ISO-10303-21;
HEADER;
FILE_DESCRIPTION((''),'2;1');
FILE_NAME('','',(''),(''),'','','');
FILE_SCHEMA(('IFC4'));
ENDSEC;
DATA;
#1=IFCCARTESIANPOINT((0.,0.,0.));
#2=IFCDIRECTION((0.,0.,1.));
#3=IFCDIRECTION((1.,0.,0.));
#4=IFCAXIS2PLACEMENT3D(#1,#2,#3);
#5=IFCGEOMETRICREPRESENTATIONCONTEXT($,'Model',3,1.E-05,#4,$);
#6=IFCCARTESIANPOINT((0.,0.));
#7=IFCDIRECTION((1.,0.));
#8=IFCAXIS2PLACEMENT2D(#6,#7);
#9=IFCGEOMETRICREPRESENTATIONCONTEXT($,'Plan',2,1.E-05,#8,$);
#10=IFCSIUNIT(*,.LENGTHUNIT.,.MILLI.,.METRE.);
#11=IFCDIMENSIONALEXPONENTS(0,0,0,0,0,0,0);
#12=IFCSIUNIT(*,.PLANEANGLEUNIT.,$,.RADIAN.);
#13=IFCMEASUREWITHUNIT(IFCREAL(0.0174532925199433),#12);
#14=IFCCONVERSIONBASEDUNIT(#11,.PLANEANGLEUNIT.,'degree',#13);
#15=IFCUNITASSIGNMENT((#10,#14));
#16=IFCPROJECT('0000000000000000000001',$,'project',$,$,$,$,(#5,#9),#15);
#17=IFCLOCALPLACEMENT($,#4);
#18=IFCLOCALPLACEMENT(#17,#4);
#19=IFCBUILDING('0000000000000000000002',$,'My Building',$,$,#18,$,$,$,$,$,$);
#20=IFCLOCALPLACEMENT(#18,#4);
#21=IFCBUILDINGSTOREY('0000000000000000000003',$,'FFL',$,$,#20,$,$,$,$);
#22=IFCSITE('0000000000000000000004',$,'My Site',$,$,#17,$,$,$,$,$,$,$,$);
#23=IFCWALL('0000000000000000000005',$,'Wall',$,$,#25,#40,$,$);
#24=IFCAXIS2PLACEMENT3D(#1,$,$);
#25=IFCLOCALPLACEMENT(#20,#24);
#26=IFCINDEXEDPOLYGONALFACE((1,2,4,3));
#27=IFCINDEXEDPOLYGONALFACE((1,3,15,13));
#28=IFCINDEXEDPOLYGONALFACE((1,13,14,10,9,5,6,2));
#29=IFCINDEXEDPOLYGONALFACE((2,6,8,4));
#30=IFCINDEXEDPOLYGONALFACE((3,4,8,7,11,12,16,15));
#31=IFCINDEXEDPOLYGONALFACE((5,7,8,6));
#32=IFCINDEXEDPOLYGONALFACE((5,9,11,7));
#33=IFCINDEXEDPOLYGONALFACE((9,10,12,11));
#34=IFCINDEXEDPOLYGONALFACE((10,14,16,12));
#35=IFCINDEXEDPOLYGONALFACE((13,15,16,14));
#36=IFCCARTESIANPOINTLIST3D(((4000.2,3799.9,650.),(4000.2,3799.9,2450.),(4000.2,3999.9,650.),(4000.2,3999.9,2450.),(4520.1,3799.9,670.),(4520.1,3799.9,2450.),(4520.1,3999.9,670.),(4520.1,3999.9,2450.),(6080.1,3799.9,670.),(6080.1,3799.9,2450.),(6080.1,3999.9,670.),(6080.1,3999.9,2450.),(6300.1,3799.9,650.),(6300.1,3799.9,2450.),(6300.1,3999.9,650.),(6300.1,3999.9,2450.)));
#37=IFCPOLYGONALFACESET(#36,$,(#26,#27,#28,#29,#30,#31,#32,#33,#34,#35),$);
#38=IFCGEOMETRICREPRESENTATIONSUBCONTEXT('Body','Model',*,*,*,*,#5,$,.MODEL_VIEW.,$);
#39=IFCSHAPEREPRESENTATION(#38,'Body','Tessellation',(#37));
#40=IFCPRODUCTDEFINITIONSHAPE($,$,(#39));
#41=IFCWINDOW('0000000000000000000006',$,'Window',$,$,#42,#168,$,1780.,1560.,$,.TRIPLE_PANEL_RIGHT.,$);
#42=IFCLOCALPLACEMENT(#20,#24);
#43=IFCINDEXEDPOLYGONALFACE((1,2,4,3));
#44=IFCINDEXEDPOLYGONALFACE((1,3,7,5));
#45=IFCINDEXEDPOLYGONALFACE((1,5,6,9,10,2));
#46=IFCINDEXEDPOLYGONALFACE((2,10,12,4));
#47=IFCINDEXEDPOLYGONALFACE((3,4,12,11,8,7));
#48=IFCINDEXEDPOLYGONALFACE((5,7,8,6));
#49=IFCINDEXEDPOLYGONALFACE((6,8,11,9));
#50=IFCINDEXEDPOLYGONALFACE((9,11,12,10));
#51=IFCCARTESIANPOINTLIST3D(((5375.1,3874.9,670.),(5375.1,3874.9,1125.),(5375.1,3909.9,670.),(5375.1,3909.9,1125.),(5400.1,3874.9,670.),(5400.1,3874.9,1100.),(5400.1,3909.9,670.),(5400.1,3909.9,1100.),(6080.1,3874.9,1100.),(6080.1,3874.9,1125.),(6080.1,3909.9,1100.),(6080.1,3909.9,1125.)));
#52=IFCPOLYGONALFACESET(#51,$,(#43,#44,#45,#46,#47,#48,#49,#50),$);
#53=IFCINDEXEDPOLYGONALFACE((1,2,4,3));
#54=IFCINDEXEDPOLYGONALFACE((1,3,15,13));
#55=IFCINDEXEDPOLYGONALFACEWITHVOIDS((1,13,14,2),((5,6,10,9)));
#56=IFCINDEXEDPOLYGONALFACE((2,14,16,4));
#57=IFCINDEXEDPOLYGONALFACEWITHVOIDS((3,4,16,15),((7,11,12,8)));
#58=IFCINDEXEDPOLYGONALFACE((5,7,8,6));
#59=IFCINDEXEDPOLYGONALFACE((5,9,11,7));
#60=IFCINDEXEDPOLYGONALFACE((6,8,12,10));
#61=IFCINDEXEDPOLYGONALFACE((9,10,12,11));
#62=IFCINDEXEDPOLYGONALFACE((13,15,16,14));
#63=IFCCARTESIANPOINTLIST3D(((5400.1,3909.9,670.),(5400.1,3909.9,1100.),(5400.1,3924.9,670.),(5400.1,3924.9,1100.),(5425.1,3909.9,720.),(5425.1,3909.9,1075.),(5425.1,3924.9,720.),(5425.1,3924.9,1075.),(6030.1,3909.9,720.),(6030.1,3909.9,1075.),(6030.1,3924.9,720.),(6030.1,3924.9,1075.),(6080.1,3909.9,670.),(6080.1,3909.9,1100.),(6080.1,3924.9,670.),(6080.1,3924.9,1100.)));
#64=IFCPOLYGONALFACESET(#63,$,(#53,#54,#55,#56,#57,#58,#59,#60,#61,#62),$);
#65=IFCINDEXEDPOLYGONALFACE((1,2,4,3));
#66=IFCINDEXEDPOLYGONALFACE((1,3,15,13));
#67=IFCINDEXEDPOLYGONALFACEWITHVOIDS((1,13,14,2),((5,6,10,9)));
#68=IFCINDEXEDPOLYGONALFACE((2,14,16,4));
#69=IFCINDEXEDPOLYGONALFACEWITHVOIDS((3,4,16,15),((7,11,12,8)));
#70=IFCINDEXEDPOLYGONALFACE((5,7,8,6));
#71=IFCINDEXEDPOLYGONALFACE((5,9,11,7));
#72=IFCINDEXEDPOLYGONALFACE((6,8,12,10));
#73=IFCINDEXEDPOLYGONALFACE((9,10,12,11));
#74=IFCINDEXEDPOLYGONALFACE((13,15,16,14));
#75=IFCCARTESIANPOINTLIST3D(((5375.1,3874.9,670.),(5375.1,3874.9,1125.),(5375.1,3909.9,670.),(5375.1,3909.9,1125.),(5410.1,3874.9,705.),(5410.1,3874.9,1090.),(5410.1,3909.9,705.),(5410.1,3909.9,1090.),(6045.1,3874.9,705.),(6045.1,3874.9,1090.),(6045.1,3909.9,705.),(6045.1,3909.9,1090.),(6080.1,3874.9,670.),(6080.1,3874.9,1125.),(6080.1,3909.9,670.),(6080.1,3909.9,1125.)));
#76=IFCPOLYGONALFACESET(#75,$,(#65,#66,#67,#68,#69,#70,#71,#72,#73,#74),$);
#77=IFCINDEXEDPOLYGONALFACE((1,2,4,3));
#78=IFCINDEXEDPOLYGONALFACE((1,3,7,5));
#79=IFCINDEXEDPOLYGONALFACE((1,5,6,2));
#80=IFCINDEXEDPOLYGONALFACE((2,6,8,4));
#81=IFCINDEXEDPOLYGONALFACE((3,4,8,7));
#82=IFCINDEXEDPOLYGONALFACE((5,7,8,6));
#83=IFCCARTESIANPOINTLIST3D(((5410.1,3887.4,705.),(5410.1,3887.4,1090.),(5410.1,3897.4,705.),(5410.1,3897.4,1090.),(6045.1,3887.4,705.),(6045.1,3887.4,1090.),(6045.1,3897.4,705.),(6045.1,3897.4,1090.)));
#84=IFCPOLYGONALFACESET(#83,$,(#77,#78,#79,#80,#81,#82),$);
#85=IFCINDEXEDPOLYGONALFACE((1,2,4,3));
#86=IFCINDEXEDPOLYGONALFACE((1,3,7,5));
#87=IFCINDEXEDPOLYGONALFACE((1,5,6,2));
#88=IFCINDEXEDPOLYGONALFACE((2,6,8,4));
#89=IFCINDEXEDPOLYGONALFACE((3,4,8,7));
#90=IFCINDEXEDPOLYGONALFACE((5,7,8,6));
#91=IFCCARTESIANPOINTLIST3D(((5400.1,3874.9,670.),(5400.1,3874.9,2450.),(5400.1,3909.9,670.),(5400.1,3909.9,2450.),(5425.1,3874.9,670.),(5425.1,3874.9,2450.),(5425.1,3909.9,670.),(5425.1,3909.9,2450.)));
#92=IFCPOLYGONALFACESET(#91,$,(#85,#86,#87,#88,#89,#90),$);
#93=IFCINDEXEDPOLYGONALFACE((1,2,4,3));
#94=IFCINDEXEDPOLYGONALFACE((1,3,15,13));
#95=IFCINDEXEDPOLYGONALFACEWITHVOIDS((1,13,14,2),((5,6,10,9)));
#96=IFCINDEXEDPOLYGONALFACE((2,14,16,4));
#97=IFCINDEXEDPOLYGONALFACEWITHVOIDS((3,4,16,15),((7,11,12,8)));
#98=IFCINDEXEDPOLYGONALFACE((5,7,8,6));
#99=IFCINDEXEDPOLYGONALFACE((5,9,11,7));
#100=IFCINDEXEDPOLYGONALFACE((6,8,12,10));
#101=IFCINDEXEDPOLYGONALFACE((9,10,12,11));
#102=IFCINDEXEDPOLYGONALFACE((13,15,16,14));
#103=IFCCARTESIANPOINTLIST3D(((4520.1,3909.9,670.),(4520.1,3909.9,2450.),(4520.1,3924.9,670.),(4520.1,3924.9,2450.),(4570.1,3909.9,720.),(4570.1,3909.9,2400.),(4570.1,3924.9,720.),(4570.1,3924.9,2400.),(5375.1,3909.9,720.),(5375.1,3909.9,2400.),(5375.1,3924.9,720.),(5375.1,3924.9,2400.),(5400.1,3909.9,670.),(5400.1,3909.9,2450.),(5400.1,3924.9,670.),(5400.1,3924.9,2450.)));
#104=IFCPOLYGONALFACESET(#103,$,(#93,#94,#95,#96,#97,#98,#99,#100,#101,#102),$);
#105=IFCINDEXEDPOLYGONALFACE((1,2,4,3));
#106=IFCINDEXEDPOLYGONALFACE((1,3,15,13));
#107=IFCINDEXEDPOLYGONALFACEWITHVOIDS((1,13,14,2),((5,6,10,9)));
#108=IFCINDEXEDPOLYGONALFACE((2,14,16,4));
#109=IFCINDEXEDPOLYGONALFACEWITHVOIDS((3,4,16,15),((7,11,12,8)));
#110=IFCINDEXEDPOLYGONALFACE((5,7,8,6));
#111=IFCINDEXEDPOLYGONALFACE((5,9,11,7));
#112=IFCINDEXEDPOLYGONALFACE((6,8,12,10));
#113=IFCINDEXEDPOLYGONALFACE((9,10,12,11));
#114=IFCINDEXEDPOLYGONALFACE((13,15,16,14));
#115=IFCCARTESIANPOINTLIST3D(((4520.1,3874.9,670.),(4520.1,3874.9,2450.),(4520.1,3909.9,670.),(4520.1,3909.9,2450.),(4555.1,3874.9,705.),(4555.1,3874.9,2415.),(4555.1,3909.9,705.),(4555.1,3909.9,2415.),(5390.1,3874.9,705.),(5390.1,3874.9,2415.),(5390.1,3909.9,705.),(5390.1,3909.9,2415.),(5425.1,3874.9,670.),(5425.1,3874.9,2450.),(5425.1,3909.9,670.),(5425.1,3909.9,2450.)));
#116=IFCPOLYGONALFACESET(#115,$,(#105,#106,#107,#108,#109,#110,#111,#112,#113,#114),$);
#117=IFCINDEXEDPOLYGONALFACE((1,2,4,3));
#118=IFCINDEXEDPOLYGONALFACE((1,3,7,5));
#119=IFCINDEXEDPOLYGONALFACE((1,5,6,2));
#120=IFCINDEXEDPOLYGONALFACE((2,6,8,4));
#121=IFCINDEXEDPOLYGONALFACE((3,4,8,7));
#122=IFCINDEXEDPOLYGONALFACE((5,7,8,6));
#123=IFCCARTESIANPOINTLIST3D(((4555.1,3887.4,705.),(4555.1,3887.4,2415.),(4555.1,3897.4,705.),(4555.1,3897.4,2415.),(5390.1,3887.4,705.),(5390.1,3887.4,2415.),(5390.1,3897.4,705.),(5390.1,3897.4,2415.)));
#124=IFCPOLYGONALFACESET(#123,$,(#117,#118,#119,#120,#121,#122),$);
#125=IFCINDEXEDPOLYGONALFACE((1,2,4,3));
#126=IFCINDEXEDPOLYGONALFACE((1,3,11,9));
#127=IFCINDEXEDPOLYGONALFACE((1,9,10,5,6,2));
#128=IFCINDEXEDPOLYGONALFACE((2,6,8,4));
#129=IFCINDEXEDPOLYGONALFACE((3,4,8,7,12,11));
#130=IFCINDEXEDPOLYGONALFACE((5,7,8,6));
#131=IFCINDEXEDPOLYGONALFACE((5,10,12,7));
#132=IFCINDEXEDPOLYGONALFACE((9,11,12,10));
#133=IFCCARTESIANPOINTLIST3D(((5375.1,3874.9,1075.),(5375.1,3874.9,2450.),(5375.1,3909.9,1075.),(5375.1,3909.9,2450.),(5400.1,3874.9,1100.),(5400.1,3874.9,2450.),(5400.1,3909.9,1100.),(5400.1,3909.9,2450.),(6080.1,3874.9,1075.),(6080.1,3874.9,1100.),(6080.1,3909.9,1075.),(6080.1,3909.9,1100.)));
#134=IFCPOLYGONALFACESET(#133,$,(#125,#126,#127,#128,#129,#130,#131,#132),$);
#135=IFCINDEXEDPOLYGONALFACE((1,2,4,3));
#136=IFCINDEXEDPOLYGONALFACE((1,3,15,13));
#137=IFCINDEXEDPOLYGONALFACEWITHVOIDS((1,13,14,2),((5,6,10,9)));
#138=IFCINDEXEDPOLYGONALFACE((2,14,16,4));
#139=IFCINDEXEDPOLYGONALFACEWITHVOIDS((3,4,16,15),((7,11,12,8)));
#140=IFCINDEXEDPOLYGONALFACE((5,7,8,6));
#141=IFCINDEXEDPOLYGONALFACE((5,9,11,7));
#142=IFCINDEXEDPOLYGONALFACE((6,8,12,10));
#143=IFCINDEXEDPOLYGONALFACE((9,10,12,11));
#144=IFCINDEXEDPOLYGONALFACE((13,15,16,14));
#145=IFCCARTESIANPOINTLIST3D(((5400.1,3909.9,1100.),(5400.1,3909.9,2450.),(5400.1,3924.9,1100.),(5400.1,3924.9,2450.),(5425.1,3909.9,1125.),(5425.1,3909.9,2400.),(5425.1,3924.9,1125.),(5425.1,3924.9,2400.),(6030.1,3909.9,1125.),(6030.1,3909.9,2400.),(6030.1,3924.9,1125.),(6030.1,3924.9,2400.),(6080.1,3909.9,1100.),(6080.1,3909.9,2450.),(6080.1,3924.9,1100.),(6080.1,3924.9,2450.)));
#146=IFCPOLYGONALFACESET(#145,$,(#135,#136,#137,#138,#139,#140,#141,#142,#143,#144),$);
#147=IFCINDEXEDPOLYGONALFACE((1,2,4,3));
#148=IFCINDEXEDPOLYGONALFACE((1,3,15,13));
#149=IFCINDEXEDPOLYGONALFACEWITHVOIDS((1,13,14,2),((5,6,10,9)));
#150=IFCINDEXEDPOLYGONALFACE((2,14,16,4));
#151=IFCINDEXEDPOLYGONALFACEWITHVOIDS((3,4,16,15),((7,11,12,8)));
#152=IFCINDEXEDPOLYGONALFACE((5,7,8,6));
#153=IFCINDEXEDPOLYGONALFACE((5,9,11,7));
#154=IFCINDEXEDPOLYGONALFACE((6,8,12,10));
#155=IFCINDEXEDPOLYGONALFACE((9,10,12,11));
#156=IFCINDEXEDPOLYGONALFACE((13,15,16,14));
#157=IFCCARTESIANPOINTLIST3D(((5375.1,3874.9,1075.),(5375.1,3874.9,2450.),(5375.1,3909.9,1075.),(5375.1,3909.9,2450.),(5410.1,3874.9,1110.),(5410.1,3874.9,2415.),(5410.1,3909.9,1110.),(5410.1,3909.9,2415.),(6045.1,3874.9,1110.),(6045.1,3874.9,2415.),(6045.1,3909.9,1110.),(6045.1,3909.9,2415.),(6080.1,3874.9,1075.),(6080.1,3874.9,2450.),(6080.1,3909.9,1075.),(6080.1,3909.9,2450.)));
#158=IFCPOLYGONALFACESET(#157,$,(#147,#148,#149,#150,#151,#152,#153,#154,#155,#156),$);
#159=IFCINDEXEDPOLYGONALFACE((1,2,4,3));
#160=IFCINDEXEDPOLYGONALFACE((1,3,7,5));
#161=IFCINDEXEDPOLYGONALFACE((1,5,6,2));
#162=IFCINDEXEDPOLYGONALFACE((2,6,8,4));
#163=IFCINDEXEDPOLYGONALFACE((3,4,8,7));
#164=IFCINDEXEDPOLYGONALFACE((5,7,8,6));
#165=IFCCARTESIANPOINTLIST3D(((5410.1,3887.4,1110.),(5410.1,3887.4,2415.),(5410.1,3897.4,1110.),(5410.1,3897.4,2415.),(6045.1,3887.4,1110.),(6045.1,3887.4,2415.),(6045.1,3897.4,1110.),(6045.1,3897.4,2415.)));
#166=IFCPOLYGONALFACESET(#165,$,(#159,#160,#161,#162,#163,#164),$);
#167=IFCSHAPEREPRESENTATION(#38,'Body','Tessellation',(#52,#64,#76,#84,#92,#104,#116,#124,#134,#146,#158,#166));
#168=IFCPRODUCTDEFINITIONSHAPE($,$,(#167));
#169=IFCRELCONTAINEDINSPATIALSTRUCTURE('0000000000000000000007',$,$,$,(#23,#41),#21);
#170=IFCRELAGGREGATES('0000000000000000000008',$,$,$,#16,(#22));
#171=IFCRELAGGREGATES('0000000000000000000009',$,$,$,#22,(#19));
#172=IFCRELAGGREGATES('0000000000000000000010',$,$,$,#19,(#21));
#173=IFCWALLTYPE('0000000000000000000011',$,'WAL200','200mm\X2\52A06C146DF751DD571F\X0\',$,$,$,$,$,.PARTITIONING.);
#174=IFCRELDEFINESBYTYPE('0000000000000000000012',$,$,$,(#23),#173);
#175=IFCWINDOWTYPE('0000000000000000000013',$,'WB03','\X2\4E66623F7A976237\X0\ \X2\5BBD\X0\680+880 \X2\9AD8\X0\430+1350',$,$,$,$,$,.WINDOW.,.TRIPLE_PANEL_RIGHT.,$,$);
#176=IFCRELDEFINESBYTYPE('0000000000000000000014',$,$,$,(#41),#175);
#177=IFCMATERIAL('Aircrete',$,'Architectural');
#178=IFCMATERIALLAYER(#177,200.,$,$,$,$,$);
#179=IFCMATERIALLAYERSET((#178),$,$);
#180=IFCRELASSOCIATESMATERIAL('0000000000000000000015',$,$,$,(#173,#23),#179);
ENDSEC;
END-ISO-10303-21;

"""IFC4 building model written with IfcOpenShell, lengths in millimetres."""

from ifc_helpers import new_model, entity, si_unit, converted_unit, frame, origin_with_axes, origin_2d_with_axis, place, context, subcontext, project, spatial, line, indexed_curve, outline, extrude, shape, source, transform, mapped, material, layer, layer_set, layer_usage, type_object, type_shapes, element, fill, save


model = new_model("IFC4")

# Units and contexts
model_context = context("Model", 3, precision=1e-05, world=origin_with_axes())
plan_context = context("Plan", 2, precision=1e-05, world=origin_2d_with_axis())
body_context_1 = subcontext(model_context, "Body", "Model", "MODEL_VIEW")
body_context_2 = subcontext(plan_context, "Body", "Plan", "PLAN_VIEW")
ifc_project = project(units=[si_unit("LENGTHUNIT", "METRE", prefix="MILLI"), converted_unit("PLANEANGLEUNIT", "degree", entity("IfcReal", 0.0174532925199433), si_unit("PLANEANGLEUNIT", "RADIAN"), dimensions=[0, 0, 0, 0, 0, 0, 0])], contexts=[model_context, plan_context])

# Site, building, storey
site_placement = place(None, origin_with_axes())
site = spatial("IfcSite", under=ifc_project, at=site_placement, Name="My Site")
building_placement = place(site_placement, origin_with_axes())
building = spatial("IfcBuilding", under=site, at=building_placement, Name="My Building")
storey_placement = place(building_placement, origin_with_axes())
storey = spatial("IfcBuildingStorey", under=building, at=storey_placement, Name="FFL")

# Shared definitions
ifc_material_1 = material(Name="Aircrete", Category="Architectural")

# Shared definitions
ifc_layer_1 = layer(ifc_material_1, 200.0)
ifc_layer_set_1 = layer_set([ifc_layer_1])
wall_type_1 = type_object("IfcWallType", Name="WAL200", Description="200mm加气混凝土", PredefinedType="PARTITIONING", material=ifc_layer_set_1)

# Wall, opening, window
ifc_layer_usage_1 = layer_usage(ifc_layer_set_1, "AXIS2", "NEGATIVE", 0.0)
wall_1_placement = place(storey_placement, frame((6300.1, 3799.9, 650.0), z_axis=(0.0, 0.0, 1.0), x_axis=(-1.0, 0.0, 0.0)))
wall_1 = element("IfcWall", 1, at=wall_1_placement, inside=storey, type_object=wall_type_1, material=ifc_layer_usage_1, Name="Wall", context=body_context_1, shape_type="SweptSolid", body=[
    extrude(outline(indexed_curve([(0.0, -200.0), (0.0, 0.0), (2299.9, 0.0), (2299.9, -200.0)], segments=[line(1, 2, 3, 4, 1)])), origin_with_axes(), (0.0, 0.0, 1.0), 1800.0),
])
shared_shape_1 = source(origin_with_axes(), body_context_1, "Body", "SweptSolid", [
    extrude(outline(indexed_curve([(0.0, 0.0), (1560.0, 0.0), (1560.0, 1780.0), (0.0, 1780.0)], segments=[line(1, 2, 3, 4, 1)])), frame((0.0, -600.0, 0.0), z_axis=(0.0, -1.0, 0.0), x_axis=(1.0, 0.0, 0.0)), (0.0, 0.0, -1.0), 1200.0),
])
opening_1_placement = place(wall_1_placement, frame((220.0, -175.0, 20.0), z_axis=(0.0, 0.0, 1.0), x_axis=(1.0, 0.0, 0.0)))
opening_1 = element("IfcOpeningElement", 2, at=opening_1_placement, cuts=wall_1, PredefinedType="OPENING", context=body_context_1, shape_type="MappedRepresentation", body=[
    mapped(shared_shape_1, transform((0.0, 0.0, 0.0), x_axis=(1.0, 0.0, 0.0), y_axis=(0.0, 1.0, 0.0), z_axis=(0.0, 0.0, 1.0), scale=1.0)),
])
window_type_1 = type_object("IfcWindowType", Name="WB03", Description="书房窗户 宽680+880 高430+1350", PartitioningType="TRIPLE_PANEL_RIGHT", PredefinedType="WINDOW")
shared_shape_2 = source(origin_with_axes(), body_context_1, "Body", "SweptSolid", [
    extrude(outline(indexed_curve([(0.0, 430.0), (680.0, 430.0), (680.0, 0.0), (705.0, 0.0), (705.0, 455.0), (0.0, 455.0)], segments=[line(1, 2, 3, 4, 5, 6, 1)])), frame((0.0, 65.0, 0.0), z_axis=(0.0, -1.0, 0.0), x_axis=(1.0, 0.0, 0.0)), (0.0, 0.0, -1.0), 35.0),
    extrude(outline(indexed_curve([(0.0, 0.0), (680.0, 0.0), (680.0, 430.0), (0.0, 430.0)], segments=[line(1, 2, 3, 4, 1)]), holes=[indexed_curve([(50.0, 50.0), (655.0, 50.0), (655.0, 405.0), (50.0, 405.0)], segments=[line(1, 2, 3, 4, 1)])]), frame((0.0, 50.0, 0.0), z_axis=(0.0, -1.0, 0.0), x_axis=(1.0, 0.0, 0.0)), (0.0, 0.0, -1.0), 15.0),
    extrude(outline(indexed_curve([(0.0, 0.0), (705.0, 0.0), (705.0, 455.0), (0.0, 455.0), (0.0, 0.0)]), holes=[indexed_curve([(35.0, 35.0), (670.0, 35.0), (670.0, 420.0), (35.0, 420.0), (35.0, 35.0)])]), frame((0.0, 65.0, 0.0), z_axis=(0.0, -1.0, 0.0), x_axis=(1.0, 0.0, 0.0)), (0.0, 0.0, -1.0), 35.0),
    extrude(outline(indexed_curve([(35.0, 35.0), (670.0, 35.0), (670.0, 420.0), (35.0, 420.0)], segments=[line(1, 2, 3, 4, 1)])), frame((0.0, 77.5, 0.0), z_axis=(0.0, -1.0, 0.0), x_axis=(1.0, 0.0, 0.0)), (0.0, 0.0, -1.0), 10.0),
    extrude(outline(indexed_curve([(0.0, 0.0), (0.0, 1780.0), (-25.0, 1780.0), (-25.0, 0.0)], segments=[line(1, 2, 3, 4, 1)])), frame((680.0, 65.0, 0.0), z_axis=(0.0, -1.0, 0.0), x_axis=(1.0, 0.0, 0.0)), (0.0, 0.0, -1.0), 35.0),
    extrude(outline(indexed_curve([(0.0, 0.0), (880.0, 0.0), (880.0, 1780.0), (0.0, 1780.0)], segments=[line(1, 2, 3, 4, 1)]), holes=[indexed_curve([(25.0, 50.0), (830.0, 50.0), (830.0, 1730.0), (25.0, 1730.0)], segments=[line(1, 2, 3, 4, 1)])]), frame((680.0, 50.0, 0.0), z_axis=(0.0, -1.0, 0.0), x_axis=(1.0, 0.0, 0.0)), (0.0, 0.0, -1.0), 15.0),
    extrude(outline(indexed_curve([(0.0, 0.0), (905.0, 0.0), (905.0, 1780.0), (0.0, 1780.0)], segments=[line(1, 2, 3, 4, 1)]), holes=[indexed_curve([(35.0, 35.0), (870.0, 35.0), (870.0, 1745.0), (35.0, 1745.0)], segments=[line(1, 2, 3, 4, 1)])]), frame((655.0, 65.0, 0.0), z_axis=(0.0, -1.0, 0.0), x_axis=(1.0, 0.0, 0.0)), (0.0, 0.0, -1.0), 35.0),
    extrude(outline(indexed_curve([(35.0, 35.0), (870.0, 35.0), (870.0, 1745.0), (35.0, 1745.0)], segments=[line(1, 2, 3, 4, 1)])), frame((655.0, 77.5, 0.0), z_axis=(0.0, -1.0, 0.0), x_axis=(1.0, 0.0, 0.0)), (0.0, 0.0, -1.0), 10.0),
    extrude(outline(indexed_curve([(680.0, 1350.0), (680.0, 0.0), (0.0, 0.0), (0.0, -25.0), (705.0, -25.0), (705.0, 1350.0)], segments=[line(1, 2, 3, 4, 5, 6, 1)])), frame((0.0, 65.0, 430.0), z_axis=(0.0, -1.0, 0.0), x_axis=(1.0, 0.0, 0.0)), (0.0, 0.0, -1.0), 35.0),
    extrude(outline(indexed_curve([(0.0, 0.0), (680.0, 0.0), (680.0, 1350.0), (0.0, 1350.0)], segments=[line(1, 2, 3, 4, 1)]), holes=[indexed_curve([(50.0, 25.0), (655.0, 25.0), (655.0, 1300.0), (50.0, 1300.0)], segments=[line(1, 2, 3, 4, 1)])]), frame((0.0, 50.0, 430.0), z_axis=(0.0, -1.0, 0.0), x_axis=(1.0, 0.0, 0.0)), (0.0, 0.0, -1.0), 15.0),
    extrude(outline(indexed_curve([(0.0, 0.0), (705.0, 0.0), (705.0, 1375.0), (0.0, 1375.0)], segments=[line(1, 2, 3, 4, 1)]), holes=[indexed_curve([(35.0, 35.0), (670.0, 35.0), (670.0, 1340.0), (35.0, 1340.0)], segments=[line(1, 2, 3, 4, 1)])]), frame((0.0, 65.0, 405.0), z_axis=(0.0, -1.0, 0.0), x_axis=(1.0, 0.0, 0.0)), (0.0, 0.0, -1.0), 35.0),
    extrude(outline(indexed_curve([(35.0, 35.0), (670.0, 35.0), (670.0, 1340.0), (35.0, 1340.0)], segments=[line(1, 2, 3, 4, 1)])), frame((0.0, 77.5, 405.0), z_axis=(0.0, -1.0, 0.0), x_axis=(1.0, 0.0, 0.0)), (0.0, 0.0, -1.0), 10.0),
])
shared_shape_3 = source(origin_with_axes(), body_context_2, "Body", "Curve2D", [
    entity("IfcIndexedPolyCurve", entity("IfcCartesianPointList2D", [[50.0, 50.0], [655.0, 50.0]])),
    entity("IfcIndexedPolyCurve", entity("IfcCartesianPointList2D", [[0.0, 100.0], [0.0, 100.0], [0.0, 65.0], [50.0, 65.0], [50.0, 50.0], [0.0, 50.0]]), [entity("IfcLineIndex", [1, 2, 3, 4, 5, 6, 1])]),
    entity("IfcIndexedPolyCurve", entity("IfcCartesianPointList2D", [[680.0, 100.0], [705.0, 100.0], [705.0, 65.0], [655.0, 65.0], [655.0, 50.0], [680.0, 50.0]])),
    entity("IfcIndexedPolyCurve", entity("IfcCartesianPointList2D", [[0.0, 65.0], [35.0, 65.0], [35.0, 100.0], [0.0, 100.0]]), [entity("IfcLineIndex", [1, 2, 3, 4, 1])]),
    entity("IfcIndexedPolyCurve", entity("IfcCartesianPointList2D", [[705.0, 65.0], [670.0, 65.0], [670.0, 100.0], [705.0, 100.0]]), [entity("IfcLineIndex", [1, 2, 3, 4, 1])]),
    entity("IfcIndexedPolyCurve", entity("IfcCartesianPointList2D", [[35.0, 65.0], [670.0, 65.0]])),
    entity("IfcIndexedPolyCurve", entity("IfcCartesianPointList2D", [[35.0, 100.0], [670.0, 100.0]])),
    entity("IfcIndexedPolyCurve", entity("IfcCartesianPointList2D", [[35.0, 82.5], [670.0, 82.5]])),
    entity("IfcIndexedPolyCurve", entity("IfcCartesianPointList2D", [[705.0, 50.0], [1510.0, 50.0]])),
    entity("IfcIndexedPolyCurve", entity("IfcCartesianPointList2D", [[680.0, 100.0], [655.0, 100.0], [655.0, 65.0], [705.0, 65.0], [705.0, 50.0], [680.0, 50.0]])),
    entity("IfcIndexedPolyCurve", entity("IfcCartesianPointList2D", [[1560.0, 100.0], [1560.0, 100.0], [1560.0, 65.0], [1510.0, 65.0], [1510.0, 50.0], [1560.0, 50.0]]), [entity("IfcLineIndex", [1, 2, 3, 4, 5, 6, 1])]),
    entity("IfcIndexedPolyCurve", entity("IfcCartesianPointList2D", [[655.0, 65.0], [690.0, 65.0], [690.0, 100.0], [655.0, 100.0]]), [entity("IfcLineIndex", [1, 2, 3, 4, 1])]),
    entity("IfcIndexedPolyCurve", entity("IfcCartesianPointList2D", [[1560.0, 65.0], [1525.0, 65.0], [1525.0, 100.0], [1560.0, 100.0]]), [entity("IfcLineIndex", [1, 2, 3, 4, 1])]),
    entity("IfcIndexedPolyCurve", entity("IfcCartesianPointList2D", [[690.0, 65.0], [1525.0, 65.0]])),
    entity("IfcIndexedPolyCurve", entity("IfcCartesianPointList2D", [[690.0, 100.0], [1525.0, 100.0]])),
    entity("IfcIndexedPolyCurve", entity("IfcCartesianPointList2D", [[690.0, 82.5], [1525.0, 82.5]])),
])
type_shapes(window_type_1, [shared_shape_2, shared_shape_3])
window_1_placement = place(opening_1_placement, frame((0.0, 0.0, 0.0), z_axis=(0.0, 0.0, 1.0), x_axis=(1.0, 0.0, 0.0)))
window_1 = element("IfcWindow", 3, at=window_1_placement, inside=storey, type_object=window_type_1, Name="Window", OverallHeight=1780.0, OverallWidth=1560.0, PartitioningType="TRIPLE_PANEL_RIGHT", shapes=[
    shape(body_context_1, "Body", "MappedRepresentation", [mapped(shared_shape_2, transform((0.0, 0.0, 0.0), x_axis=(1.0, 0.0, 0.0), y_axis=(0.0, 1.0, 0.0), z_axis=(0.0, 0.0, 1.0), scale=1.0))]),
    shape(body_context_2, "Body", "MappedRepresentation", [mapped(shared_shape_3, transform((0.0, 0.0, 0.0), x_axis=(1.0, 0.0, 0.0), y_axis=(0.0, 1.0, 0.0), z_axis=(0.0, 0.0, 1.0), scale=1.0))]),
])
fill(opening_1, window_1)

save(model, "model.ifc")
